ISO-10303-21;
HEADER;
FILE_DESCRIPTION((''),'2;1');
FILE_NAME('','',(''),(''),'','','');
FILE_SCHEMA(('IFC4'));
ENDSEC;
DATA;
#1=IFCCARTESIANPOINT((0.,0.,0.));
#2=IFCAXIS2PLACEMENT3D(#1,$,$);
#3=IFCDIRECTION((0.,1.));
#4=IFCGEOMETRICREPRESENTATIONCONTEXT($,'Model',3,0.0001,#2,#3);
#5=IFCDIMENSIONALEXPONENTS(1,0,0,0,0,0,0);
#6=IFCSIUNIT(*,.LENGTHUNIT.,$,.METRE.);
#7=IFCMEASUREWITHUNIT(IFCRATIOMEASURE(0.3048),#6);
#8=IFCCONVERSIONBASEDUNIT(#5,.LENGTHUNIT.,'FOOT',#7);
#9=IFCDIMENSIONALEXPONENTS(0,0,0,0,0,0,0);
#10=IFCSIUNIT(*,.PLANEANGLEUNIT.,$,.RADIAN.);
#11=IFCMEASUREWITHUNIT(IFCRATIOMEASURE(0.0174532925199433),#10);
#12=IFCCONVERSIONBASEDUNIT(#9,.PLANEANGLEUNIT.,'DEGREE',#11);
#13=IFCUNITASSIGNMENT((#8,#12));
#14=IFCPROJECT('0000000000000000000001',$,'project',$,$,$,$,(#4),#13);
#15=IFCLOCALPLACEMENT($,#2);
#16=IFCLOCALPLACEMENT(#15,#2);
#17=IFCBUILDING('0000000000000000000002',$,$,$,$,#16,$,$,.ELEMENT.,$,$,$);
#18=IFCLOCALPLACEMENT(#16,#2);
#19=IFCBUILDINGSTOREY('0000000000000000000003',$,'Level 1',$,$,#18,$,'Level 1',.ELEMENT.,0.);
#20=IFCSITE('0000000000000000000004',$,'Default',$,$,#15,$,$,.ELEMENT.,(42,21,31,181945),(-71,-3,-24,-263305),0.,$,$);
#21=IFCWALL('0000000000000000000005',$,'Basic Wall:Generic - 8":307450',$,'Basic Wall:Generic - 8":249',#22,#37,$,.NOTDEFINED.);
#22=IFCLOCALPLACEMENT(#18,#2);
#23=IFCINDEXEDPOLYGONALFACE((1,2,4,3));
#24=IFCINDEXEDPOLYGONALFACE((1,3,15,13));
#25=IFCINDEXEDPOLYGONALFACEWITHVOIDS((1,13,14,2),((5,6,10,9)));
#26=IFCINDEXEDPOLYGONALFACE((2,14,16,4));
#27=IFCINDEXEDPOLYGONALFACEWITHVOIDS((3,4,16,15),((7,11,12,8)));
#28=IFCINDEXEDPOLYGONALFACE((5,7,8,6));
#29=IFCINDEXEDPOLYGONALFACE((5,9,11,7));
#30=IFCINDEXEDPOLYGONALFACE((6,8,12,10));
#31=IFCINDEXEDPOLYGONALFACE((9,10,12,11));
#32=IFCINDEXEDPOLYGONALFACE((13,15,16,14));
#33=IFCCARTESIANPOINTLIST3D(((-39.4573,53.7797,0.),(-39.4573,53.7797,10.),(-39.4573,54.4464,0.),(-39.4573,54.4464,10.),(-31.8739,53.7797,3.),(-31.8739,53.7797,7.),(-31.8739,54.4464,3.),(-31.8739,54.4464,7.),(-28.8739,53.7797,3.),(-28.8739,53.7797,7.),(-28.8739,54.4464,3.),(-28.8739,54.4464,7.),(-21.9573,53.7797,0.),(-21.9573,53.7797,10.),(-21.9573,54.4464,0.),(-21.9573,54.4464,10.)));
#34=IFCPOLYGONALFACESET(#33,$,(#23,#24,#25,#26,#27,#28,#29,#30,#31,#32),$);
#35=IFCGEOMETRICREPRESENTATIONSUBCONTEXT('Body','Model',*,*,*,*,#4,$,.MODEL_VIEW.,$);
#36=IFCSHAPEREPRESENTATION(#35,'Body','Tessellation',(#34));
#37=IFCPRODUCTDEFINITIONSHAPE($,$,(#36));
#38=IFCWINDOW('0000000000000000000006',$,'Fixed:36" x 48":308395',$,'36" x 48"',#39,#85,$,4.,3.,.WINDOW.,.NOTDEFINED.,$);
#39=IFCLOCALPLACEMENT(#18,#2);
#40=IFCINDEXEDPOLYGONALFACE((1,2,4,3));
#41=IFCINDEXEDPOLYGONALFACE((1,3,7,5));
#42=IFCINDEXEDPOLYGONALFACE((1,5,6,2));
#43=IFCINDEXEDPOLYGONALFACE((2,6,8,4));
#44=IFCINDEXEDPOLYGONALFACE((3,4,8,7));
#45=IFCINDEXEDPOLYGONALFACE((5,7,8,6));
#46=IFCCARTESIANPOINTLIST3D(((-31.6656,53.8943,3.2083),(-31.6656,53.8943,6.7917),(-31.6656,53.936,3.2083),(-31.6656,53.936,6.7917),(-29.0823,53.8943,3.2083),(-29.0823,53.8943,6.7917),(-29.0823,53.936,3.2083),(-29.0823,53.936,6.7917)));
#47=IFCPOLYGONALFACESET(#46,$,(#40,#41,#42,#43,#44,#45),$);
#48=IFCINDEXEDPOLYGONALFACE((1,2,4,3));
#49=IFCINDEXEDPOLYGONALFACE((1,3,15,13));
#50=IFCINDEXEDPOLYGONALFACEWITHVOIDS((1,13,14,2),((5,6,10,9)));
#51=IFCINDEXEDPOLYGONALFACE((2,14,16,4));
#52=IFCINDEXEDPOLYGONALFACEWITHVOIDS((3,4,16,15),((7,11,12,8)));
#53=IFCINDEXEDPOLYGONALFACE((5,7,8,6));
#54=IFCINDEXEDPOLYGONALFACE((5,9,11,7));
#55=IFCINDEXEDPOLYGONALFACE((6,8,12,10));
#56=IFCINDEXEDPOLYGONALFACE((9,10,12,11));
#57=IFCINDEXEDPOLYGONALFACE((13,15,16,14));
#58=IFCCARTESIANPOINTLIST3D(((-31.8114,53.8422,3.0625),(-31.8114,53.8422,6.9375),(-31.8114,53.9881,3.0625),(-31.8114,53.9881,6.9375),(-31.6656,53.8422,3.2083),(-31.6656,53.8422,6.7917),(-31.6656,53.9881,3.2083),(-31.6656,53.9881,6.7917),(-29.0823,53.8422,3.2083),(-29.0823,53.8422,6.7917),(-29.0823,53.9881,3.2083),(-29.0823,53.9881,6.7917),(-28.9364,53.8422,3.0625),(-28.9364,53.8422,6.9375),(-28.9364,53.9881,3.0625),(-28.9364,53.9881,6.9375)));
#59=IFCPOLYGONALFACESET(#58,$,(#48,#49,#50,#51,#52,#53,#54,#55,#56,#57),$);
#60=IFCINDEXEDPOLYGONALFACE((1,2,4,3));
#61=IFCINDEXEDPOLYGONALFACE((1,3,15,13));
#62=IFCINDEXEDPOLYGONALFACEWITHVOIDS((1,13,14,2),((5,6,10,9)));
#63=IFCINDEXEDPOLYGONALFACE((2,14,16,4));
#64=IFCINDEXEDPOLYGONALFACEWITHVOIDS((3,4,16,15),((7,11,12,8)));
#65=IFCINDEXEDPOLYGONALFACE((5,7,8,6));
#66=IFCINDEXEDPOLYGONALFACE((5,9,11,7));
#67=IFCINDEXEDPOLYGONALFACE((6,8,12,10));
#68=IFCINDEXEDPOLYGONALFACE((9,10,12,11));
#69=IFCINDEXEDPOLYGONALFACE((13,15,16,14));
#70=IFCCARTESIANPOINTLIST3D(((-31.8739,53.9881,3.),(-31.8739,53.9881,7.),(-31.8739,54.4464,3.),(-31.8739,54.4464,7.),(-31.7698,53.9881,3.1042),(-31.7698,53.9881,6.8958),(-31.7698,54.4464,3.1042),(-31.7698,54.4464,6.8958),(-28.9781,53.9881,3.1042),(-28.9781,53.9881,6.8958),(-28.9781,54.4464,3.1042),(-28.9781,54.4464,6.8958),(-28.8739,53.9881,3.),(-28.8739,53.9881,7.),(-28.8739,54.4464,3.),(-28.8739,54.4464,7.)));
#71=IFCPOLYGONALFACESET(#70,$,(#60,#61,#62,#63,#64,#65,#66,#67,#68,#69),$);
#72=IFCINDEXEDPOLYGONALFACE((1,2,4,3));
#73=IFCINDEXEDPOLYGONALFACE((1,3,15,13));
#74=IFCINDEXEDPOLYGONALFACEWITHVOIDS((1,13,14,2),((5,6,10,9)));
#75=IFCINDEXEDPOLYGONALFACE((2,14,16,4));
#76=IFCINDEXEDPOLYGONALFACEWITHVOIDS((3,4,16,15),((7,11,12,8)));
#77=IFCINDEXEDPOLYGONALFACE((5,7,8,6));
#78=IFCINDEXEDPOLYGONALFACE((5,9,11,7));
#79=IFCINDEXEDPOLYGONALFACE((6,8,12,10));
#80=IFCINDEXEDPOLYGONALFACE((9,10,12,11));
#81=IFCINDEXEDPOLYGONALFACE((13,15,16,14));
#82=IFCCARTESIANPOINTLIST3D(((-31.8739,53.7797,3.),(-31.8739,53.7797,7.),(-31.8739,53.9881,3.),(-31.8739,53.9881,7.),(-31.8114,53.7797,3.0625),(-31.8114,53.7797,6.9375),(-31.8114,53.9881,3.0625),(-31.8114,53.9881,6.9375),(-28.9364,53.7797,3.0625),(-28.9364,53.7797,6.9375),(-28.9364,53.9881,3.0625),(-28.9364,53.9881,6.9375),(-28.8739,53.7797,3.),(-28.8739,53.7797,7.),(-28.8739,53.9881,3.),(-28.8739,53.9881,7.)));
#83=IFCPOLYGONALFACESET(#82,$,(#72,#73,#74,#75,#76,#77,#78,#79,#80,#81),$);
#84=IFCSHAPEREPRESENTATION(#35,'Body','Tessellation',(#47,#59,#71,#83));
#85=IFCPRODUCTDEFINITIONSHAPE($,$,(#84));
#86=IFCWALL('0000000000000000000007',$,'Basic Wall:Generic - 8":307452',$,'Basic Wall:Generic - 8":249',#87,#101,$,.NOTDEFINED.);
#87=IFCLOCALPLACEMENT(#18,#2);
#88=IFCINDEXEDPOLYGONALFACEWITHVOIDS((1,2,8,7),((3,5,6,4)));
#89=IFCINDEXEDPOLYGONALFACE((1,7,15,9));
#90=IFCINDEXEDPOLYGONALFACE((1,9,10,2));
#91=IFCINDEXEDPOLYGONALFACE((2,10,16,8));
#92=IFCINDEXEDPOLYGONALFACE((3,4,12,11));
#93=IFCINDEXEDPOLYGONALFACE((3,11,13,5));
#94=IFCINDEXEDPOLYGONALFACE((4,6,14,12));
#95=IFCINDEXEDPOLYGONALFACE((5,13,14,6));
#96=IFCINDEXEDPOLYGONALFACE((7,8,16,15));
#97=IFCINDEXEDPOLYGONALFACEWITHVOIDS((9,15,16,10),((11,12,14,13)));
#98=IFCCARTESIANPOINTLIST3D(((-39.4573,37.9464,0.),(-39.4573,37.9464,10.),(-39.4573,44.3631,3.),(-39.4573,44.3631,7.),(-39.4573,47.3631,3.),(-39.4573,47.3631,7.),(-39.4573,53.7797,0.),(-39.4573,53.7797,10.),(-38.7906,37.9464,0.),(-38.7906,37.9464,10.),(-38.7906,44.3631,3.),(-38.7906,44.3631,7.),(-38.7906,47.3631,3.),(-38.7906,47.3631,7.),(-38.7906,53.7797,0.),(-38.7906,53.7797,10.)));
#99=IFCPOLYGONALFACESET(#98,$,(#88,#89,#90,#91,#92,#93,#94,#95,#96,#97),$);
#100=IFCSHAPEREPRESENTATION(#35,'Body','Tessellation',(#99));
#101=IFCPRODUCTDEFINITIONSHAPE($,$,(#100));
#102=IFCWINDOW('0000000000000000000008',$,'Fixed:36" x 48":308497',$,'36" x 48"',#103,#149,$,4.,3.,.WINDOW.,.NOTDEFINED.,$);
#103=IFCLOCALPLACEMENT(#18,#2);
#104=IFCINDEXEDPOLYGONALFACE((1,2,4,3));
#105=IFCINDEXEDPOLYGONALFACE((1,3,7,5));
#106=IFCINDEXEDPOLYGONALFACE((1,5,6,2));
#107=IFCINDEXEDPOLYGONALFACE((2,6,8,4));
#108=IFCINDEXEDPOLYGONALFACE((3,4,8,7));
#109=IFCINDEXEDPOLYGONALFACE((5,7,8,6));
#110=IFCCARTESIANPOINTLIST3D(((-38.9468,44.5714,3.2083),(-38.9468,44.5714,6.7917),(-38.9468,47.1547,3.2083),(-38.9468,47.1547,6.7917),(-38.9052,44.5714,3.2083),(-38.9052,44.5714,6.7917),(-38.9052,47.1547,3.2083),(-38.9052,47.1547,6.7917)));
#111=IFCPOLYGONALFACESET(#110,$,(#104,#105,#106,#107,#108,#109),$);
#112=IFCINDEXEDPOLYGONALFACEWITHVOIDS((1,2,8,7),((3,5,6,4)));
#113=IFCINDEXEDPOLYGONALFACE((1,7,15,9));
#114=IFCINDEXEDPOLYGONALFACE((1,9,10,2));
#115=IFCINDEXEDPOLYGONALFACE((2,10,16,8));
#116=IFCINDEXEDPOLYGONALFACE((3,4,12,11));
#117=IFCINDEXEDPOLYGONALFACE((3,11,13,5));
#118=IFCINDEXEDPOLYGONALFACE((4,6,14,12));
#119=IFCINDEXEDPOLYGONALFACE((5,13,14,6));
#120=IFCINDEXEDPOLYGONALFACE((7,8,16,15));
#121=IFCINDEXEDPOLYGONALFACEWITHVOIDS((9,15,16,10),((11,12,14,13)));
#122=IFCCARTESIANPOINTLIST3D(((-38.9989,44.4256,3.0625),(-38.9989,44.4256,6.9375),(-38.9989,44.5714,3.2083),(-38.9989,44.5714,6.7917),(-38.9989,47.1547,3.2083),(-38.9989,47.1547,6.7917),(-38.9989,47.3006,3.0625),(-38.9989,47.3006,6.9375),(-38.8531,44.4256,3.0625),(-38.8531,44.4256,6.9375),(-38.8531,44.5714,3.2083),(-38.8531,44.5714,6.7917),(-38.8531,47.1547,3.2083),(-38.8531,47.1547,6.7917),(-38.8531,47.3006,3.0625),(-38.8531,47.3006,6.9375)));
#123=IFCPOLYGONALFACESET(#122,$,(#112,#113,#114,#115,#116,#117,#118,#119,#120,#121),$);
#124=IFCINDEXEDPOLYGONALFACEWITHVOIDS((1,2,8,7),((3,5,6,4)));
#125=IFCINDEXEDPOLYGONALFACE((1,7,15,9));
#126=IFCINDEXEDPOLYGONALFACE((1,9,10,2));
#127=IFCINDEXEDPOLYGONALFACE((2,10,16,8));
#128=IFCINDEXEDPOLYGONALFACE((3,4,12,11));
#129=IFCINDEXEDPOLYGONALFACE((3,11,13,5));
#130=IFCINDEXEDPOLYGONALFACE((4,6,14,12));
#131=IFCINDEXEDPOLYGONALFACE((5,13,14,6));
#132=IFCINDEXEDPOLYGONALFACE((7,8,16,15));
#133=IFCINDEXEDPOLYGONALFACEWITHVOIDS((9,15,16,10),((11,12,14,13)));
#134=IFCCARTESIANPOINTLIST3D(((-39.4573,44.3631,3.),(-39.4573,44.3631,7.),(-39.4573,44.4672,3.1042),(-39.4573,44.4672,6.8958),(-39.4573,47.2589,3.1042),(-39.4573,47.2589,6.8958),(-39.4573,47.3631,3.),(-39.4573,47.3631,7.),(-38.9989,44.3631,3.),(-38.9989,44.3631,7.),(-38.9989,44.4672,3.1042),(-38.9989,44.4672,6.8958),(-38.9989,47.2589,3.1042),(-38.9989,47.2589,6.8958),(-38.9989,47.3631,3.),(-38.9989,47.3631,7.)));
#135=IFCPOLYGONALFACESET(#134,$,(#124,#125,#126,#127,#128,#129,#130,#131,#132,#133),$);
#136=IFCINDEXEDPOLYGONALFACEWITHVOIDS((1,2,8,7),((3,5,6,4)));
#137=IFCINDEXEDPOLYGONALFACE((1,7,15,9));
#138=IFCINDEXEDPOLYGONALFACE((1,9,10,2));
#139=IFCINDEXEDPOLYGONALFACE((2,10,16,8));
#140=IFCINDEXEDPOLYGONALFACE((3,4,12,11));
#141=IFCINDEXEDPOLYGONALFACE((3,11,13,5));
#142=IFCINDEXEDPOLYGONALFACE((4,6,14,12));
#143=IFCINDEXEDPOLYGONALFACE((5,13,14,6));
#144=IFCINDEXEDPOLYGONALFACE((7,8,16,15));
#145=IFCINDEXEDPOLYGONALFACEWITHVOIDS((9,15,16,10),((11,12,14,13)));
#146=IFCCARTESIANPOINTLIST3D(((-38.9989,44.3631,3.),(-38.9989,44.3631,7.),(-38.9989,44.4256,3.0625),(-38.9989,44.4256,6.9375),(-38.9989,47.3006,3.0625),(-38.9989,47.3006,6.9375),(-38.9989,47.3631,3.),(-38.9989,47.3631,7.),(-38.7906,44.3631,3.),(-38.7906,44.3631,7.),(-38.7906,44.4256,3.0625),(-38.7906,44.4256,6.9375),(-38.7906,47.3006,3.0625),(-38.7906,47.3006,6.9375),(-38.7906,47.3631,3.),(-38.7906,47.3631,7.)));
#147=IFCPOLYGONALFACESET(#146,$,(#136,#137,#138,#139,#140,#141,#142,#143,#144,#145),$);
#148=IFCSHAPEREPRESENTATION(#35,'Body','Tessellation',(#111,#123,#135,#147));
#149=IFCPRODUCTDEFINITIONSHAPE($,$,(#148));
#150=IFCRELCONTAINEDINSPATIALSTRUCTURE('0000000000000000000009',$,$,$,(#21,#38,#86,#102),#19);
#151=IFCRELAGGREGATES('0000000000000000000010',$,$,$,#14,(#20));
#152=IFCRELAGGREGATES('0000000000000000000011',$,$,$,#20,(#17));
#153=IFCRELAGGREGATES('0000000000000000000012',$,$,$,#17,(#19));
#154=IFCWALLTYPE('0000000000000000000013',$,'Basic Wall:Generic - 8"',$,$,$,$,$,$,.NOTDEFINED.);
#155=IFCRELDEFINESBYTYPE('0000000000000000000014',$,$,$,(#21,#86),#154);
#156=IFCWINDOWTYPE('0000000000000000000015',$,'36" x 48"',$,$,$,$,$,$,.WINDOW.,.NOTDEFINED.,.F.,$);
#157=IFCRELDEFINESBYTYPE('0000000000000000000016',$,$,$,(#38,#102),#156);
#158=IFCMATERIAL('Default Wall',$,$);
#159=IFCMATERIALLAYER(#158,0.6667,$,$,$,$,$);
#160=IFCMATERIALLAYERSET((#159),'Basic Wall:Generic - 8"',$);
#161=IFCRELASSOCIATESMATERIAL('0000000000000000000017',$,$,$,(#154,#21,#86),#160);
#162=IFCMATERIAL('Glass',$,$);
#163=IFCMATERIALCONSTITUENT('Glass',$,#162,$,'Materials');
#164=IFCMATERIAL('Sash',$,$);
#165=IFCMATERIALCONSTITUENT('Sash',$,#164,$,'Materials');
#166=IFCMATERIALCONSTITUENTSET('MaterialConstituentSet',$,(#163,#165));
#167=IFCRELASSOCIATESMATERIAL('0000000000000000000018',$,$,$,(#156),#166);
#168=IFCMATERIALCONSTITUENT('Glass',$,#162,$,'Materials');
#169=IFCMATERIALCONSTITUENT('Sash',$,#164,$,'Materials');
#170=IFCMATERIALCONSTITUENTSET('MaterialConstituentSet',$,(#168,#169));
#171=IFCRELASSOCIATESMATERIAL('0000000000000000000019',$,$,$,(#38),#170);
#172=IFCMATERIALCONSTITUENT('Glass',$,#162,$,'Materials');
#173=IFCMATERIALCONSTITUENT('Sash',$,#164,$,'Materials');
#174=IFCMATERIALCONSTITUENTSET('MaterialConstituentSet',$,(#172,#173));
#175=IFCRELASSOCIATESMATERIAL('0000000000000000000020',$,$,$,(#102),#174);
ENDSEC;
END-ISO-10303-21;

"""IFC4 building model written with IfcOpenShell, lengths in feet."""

from ifc_helpers import new_model, entity, si_unit, converted_unit, direction, frame, frame_2d, origin, place, context, subcontext, project, spatial, polyline, rectangle, outline, extrude, source, transform, mapped, material, layer, layer_set, layer_usage, constituent, constituent_set, type_object, type_shapes, element, fill, save


model = new_model("IFC4")

# Units and contexts
model_context = context("Model", 3, precision=0.0001, world=origin(), true_north=direction((0.0, 1.0)))
body_context = subcontext(model_context, "Body", "Model", "MODEL_VIEW")
ifc_project = project(units=[converted_unit("LENGTHUNIT", "FOOT", entity("IfcRatioMeasure", 0.3048), si_unit("LENGTHUNIT", "METRE"), dimensions=[1, 0, 0, 0, 0, 0, 0]), converted_unit("PLANEANGLEUNIT", "DEGREE", entity("IfcRatioMeasure", 0.0174532925199433), si_unit("PLANEANGLEUNIT", "RADIAN"), dimensions=[0, 0, 0, 0, 0, 0, 0])], contexts=[model_context])

# Site, building, storey
site_placement = place(None, origin())
site = spatial("IfcSite", under=ifc_project, at=site_placement, Name="Default", CompositionType="ELEMENT", RefLatitude=(42, 21, 31, 181945), RefLongitude=(-71, -3, -24, -263305), RefElevation=0.0)
building_placement = place(site_placement, origin())
building = spatial("IfcBuilding", under=site, at=building_placement, CompositionType="ELEMENT")
storey_placement = place(building_placement, origin())
storey = spatial("IfcBuildingStorey", under=building, at=storey_placement, Name="Level 1", LongName="Level 1", CompositionType="ELEMENT", Elevation=0.0)

# Shared definitions
ifc_material_1 = material(Name="Default Wall")
ifc_layer = layer(ifc_material_1, 0.6667)
ifc_layer_set = layer_set([ifc_layer], Name="Basic Wall:Generic - 8\"")
wall_type = type_object("IfcWallType", Name="Basic Wall:Generic - 8\"", PredefinedType="NOTDEFINED", material=ifc_layer_set)
ifc_material_2 = material(Name="Glass")
ifc_material_3 = material(Name="Sash")
ifc_constituent_1 = constituent(ifc_material_2, Name="Glass", Category="Materials")
ifc_constituent_2 = constituent(ifc_material_3, Name="Sash", Category="Materials")
ifc_constituent_set_1 = constituent_set(constituents=[ifc_constituent_1, ifc_constituent_2], Name="MaterialConstituentSet")
window_type_1 = type_object("IfcWindowType", Name="36\" x 48\"", ParameterTakesPrecedence=False, PartitioningType="NOTDEFINED", PredefinedType="WINDOW", material=ifc_constituent_set_1)
shared_shape_1 = source(origin(), body_context, "Body", "SweptSolid", [
    extrude(rectangle(XDim=0.0417, YDim=2.5833, at=frame_2d((0.0, 0.0), x_axis=(1.0, 0.0))), frame((1.5, 0.5312, 0.2083), z_axis=(0.0, 0.0, 1.0), x_axis=(0.0, 1.0, 0.0)), (0.0, 0.0, 1.0), 3.5833),
    extrude(outline(polyline([(-1.4375, -1.9375), (1.4375, -1.9375), (1.4375, 1.9375), (-1.4375, 1.9375), (-1.4375, -1.9375)]), holes=[polyline([(-1.2917, -1.7917), (-1.2917, 1.7917), (1.2917, 1.7917), (1.2917, -1.7917), (-1.2917, -1.7917)])]), frame((1.5, 0.4583, 2.0), z_axis=(0.0, 1.0, 0.0), x_axis=(1.0, 0.0, 0.0)), (0.0, 0.0, 1.0), 0.1458),
    extrude(outline(polyline([(-1.5, -2.0), (1.5, -2.0), (1.5, 2.0), (-1.5, 2.0), (-1.5, -2.0)]), holes=[polyline([(-1.3958, -1.8958), (-1.3958, 1.8958), (1.3958, 1.8958), (1.3958, -1.8958), (-1.3958, -1.8958)])]), frame((1.5, 0.0, 2.0), z_axis=(0.0, 1.0, 0.0), x_axis=(1.0, 0.0, 0.0)), (0.0, 0.0, 1.0), 0.4583),
    extrude(outline(polyline([(-2.0, -1.5), (2.0, -1.5), (2.0, 1.5), (-2.0, 1.5), (-2.0, -1.5)]), holes=[polyline([(-1.9375, -1.4375), (-1.9375, 1.4375), (1.9375, 1.4375), (1.9375, -1.4375), (-1.9375, -1.4375)])]), frame((1.5, 0.4583, 2.0), z_axis=(0.0, 1.0, 0.0), x_axis=(0.0, 0.0, -1.0)), (0.0, 0.0, 1.0), 0.2083),
])
type_shapes(window_type_1, [shared_shape_1])

# Walls, openings, windows
ifc_layer_usage_1 = layer_usage(ifc_layer_set, "AXIS2", "NEGATIVE", 0.3333)
wall_1_placement = place(storey_placement, frame((-39.4573, 54.1131, 0.0)))
wall_1 = element("IfcWall", 1, at=wall_1_placement, inside=storey, type_object=wall_type, material=ifc_layer_usage_1, Name="Basic Wall:Generic - 8\":307450", ObjectType="Basic Wall:Generic - 8\":249", PredefinedType="NOTDEFINED", context=body_context, shape_type="SweptSolid", body=[
    extrude(rectangle(XDim=17.5, YDim=0.6667, at=frame_2d((8.75, 0.0), x_axis=(-1.0, 0.0))), origin(), (0.0, 0.0, 1.0), 10.0),
])
opening_1_placement = place(wall_1_placement, frame((10.5833, 0.3333, 3.0)))
opening_1 = element("IfcOpeningElement", 2, at=opening_1_placement, cuts=wall_1, ObjectType="Opening", PredefinedType="OPENING", context=body_context, shape_type="SweptSolid", body=[
    extrude(rectangle(XDim=4.0, YDim=3.0, at=frame_2d((2.0, 1.5), x_axis=(-1.0, 0.0))), frame((0.0, 0.0, 0.0), z_axis=(0.0, -1.0, 0.0), x_axis=(0.0, 0.0, 1.0)), (0.0, 0.0, 1.0), 0.6667),
])
ifc_constituent_3 = constituent(ifc_material_2, Name="Glass", Category="Materials")
ifc_constituent_4 = constituent(ifc_material_3, Name="Sash", Category="Materials")
ifc_constituent_set_2 = constituent_set(constituents=[ifc_constituent_3, ifc_constituent_4], Name="MaterialConstituentSet")
window_1_placement = place(opening_1_placement, frame((0.0, 0.0, 0.0), z_axis=(0.0, 0.0, 1.0), x_axis=(-1.0, 0.0, 0.0)))
window_1 = element("IfcWindow", 3, at=window_1_placement, inside=storey, type_object=window_type_1, material=ifc_constituent_set_2, Name="Fixed:36\" x 48\":308395", ObjectType="36\" x 48\"", OverallHeight=4.0, OverallWidth=3.0, PartitioningType="NOTDEFINED", PredefinedType="WINDOW", context=body_context, shape_type="MappedRepresentation", body=[
    mapped(shared_shape_1, transform((0.0, 0.0, 0.0), scale=1.0)),
])
fill(opening_1, window_1)
ifc_layer_usage_2 = layer_usage(ifc_layer_set, "AXIS2", "NEGATIVE", 0.3333)
wall_2_placement = place(storey_placement, frame((-39.1239, 37.9464, 0.0), z_axis=(0.0, 0.0, 1.0), x_axis=(0.0, 1.0, 0.0)))
wall_2 = element("IfcWall", 4, at=wall_2_placement, inside=storey, type_object=wall_type, material=ifc_layer_usage_2, Name="Basic Wall:Generic - 8\":307452", ObjectType="Basic Wall:Generic - 8\":249", PredefinedType="NOTDEFINED", context=body_context, shape_type="SweptSolid", body=[
    extrude(rectangle(XDim=15.8333, YDim=0.6667, at=frame_2d((7.9167, 0.0), x_axis=(-1.0, 0.0))), origin(), (0.0, 0.0, 1.0), 10.0),
])
opening_2_placement = place(wall_2_placement, frame((9.4167, 0.3333, 3.0)))
opening_2 = element("IfcOpeningElement", 5, at=opening_2_placement, cuts=wall_2, ObjectType="Opening", PredefinedType="OPENING", context=body_context, shape_type="SweptSolid", body=[
    extrude(rectangle(XDim=4.0, YDim=3.0, at=frame_2d((2.0, 1.5), x_axis=(-1.0, 0.0))), frame((0.0, 0.0, 0.0), z_axis=(0.0, -1.0, 0.0), x_axis=(0.0, 0.0, 1.0)), (0.0, 0.0, 1.0), 0.6667),
])
ifc_constituent_5 = constituent(ifc_material_2, Name="Glass", Category="Materials")
ifc_constituent_6 = constituent(ifc_material_3, Name="Sash", Category="Materials")
ifc_constituent_set_3 = constituent_set(constituents=[ifc_constituent_5, ifc_constituent_6], Name="MaterialConstituentSet")
window_2_placement = place(opening_2_placement, frame((0.0, 0.0, 0.0), z_axis=(0.0, 0.0, 1.0), x_axis=(-1.0, 0.0, 0.0)))
window_2 = element("IfcWindow", 6, at=window_2_placement, inside=storey, type_object=window_type_1, material=ifc_constituent_set_3, Name="Fixed:36\" x 48\":308497", ObjectType="36\" x 48\"", OverallHeight=4.0, OverallWidth=3.0, PartitioningType="NOTDEFINED", PredefinedType="WINDOW", context=body_context, shape_type="MappedRepresentation", body=[
    mapped(shared_shape_1, transform((0.0, 0.0, 0.0), scale=1.0)),
])
fill(opening_2, window_2)

save(model, "model.ifc")
